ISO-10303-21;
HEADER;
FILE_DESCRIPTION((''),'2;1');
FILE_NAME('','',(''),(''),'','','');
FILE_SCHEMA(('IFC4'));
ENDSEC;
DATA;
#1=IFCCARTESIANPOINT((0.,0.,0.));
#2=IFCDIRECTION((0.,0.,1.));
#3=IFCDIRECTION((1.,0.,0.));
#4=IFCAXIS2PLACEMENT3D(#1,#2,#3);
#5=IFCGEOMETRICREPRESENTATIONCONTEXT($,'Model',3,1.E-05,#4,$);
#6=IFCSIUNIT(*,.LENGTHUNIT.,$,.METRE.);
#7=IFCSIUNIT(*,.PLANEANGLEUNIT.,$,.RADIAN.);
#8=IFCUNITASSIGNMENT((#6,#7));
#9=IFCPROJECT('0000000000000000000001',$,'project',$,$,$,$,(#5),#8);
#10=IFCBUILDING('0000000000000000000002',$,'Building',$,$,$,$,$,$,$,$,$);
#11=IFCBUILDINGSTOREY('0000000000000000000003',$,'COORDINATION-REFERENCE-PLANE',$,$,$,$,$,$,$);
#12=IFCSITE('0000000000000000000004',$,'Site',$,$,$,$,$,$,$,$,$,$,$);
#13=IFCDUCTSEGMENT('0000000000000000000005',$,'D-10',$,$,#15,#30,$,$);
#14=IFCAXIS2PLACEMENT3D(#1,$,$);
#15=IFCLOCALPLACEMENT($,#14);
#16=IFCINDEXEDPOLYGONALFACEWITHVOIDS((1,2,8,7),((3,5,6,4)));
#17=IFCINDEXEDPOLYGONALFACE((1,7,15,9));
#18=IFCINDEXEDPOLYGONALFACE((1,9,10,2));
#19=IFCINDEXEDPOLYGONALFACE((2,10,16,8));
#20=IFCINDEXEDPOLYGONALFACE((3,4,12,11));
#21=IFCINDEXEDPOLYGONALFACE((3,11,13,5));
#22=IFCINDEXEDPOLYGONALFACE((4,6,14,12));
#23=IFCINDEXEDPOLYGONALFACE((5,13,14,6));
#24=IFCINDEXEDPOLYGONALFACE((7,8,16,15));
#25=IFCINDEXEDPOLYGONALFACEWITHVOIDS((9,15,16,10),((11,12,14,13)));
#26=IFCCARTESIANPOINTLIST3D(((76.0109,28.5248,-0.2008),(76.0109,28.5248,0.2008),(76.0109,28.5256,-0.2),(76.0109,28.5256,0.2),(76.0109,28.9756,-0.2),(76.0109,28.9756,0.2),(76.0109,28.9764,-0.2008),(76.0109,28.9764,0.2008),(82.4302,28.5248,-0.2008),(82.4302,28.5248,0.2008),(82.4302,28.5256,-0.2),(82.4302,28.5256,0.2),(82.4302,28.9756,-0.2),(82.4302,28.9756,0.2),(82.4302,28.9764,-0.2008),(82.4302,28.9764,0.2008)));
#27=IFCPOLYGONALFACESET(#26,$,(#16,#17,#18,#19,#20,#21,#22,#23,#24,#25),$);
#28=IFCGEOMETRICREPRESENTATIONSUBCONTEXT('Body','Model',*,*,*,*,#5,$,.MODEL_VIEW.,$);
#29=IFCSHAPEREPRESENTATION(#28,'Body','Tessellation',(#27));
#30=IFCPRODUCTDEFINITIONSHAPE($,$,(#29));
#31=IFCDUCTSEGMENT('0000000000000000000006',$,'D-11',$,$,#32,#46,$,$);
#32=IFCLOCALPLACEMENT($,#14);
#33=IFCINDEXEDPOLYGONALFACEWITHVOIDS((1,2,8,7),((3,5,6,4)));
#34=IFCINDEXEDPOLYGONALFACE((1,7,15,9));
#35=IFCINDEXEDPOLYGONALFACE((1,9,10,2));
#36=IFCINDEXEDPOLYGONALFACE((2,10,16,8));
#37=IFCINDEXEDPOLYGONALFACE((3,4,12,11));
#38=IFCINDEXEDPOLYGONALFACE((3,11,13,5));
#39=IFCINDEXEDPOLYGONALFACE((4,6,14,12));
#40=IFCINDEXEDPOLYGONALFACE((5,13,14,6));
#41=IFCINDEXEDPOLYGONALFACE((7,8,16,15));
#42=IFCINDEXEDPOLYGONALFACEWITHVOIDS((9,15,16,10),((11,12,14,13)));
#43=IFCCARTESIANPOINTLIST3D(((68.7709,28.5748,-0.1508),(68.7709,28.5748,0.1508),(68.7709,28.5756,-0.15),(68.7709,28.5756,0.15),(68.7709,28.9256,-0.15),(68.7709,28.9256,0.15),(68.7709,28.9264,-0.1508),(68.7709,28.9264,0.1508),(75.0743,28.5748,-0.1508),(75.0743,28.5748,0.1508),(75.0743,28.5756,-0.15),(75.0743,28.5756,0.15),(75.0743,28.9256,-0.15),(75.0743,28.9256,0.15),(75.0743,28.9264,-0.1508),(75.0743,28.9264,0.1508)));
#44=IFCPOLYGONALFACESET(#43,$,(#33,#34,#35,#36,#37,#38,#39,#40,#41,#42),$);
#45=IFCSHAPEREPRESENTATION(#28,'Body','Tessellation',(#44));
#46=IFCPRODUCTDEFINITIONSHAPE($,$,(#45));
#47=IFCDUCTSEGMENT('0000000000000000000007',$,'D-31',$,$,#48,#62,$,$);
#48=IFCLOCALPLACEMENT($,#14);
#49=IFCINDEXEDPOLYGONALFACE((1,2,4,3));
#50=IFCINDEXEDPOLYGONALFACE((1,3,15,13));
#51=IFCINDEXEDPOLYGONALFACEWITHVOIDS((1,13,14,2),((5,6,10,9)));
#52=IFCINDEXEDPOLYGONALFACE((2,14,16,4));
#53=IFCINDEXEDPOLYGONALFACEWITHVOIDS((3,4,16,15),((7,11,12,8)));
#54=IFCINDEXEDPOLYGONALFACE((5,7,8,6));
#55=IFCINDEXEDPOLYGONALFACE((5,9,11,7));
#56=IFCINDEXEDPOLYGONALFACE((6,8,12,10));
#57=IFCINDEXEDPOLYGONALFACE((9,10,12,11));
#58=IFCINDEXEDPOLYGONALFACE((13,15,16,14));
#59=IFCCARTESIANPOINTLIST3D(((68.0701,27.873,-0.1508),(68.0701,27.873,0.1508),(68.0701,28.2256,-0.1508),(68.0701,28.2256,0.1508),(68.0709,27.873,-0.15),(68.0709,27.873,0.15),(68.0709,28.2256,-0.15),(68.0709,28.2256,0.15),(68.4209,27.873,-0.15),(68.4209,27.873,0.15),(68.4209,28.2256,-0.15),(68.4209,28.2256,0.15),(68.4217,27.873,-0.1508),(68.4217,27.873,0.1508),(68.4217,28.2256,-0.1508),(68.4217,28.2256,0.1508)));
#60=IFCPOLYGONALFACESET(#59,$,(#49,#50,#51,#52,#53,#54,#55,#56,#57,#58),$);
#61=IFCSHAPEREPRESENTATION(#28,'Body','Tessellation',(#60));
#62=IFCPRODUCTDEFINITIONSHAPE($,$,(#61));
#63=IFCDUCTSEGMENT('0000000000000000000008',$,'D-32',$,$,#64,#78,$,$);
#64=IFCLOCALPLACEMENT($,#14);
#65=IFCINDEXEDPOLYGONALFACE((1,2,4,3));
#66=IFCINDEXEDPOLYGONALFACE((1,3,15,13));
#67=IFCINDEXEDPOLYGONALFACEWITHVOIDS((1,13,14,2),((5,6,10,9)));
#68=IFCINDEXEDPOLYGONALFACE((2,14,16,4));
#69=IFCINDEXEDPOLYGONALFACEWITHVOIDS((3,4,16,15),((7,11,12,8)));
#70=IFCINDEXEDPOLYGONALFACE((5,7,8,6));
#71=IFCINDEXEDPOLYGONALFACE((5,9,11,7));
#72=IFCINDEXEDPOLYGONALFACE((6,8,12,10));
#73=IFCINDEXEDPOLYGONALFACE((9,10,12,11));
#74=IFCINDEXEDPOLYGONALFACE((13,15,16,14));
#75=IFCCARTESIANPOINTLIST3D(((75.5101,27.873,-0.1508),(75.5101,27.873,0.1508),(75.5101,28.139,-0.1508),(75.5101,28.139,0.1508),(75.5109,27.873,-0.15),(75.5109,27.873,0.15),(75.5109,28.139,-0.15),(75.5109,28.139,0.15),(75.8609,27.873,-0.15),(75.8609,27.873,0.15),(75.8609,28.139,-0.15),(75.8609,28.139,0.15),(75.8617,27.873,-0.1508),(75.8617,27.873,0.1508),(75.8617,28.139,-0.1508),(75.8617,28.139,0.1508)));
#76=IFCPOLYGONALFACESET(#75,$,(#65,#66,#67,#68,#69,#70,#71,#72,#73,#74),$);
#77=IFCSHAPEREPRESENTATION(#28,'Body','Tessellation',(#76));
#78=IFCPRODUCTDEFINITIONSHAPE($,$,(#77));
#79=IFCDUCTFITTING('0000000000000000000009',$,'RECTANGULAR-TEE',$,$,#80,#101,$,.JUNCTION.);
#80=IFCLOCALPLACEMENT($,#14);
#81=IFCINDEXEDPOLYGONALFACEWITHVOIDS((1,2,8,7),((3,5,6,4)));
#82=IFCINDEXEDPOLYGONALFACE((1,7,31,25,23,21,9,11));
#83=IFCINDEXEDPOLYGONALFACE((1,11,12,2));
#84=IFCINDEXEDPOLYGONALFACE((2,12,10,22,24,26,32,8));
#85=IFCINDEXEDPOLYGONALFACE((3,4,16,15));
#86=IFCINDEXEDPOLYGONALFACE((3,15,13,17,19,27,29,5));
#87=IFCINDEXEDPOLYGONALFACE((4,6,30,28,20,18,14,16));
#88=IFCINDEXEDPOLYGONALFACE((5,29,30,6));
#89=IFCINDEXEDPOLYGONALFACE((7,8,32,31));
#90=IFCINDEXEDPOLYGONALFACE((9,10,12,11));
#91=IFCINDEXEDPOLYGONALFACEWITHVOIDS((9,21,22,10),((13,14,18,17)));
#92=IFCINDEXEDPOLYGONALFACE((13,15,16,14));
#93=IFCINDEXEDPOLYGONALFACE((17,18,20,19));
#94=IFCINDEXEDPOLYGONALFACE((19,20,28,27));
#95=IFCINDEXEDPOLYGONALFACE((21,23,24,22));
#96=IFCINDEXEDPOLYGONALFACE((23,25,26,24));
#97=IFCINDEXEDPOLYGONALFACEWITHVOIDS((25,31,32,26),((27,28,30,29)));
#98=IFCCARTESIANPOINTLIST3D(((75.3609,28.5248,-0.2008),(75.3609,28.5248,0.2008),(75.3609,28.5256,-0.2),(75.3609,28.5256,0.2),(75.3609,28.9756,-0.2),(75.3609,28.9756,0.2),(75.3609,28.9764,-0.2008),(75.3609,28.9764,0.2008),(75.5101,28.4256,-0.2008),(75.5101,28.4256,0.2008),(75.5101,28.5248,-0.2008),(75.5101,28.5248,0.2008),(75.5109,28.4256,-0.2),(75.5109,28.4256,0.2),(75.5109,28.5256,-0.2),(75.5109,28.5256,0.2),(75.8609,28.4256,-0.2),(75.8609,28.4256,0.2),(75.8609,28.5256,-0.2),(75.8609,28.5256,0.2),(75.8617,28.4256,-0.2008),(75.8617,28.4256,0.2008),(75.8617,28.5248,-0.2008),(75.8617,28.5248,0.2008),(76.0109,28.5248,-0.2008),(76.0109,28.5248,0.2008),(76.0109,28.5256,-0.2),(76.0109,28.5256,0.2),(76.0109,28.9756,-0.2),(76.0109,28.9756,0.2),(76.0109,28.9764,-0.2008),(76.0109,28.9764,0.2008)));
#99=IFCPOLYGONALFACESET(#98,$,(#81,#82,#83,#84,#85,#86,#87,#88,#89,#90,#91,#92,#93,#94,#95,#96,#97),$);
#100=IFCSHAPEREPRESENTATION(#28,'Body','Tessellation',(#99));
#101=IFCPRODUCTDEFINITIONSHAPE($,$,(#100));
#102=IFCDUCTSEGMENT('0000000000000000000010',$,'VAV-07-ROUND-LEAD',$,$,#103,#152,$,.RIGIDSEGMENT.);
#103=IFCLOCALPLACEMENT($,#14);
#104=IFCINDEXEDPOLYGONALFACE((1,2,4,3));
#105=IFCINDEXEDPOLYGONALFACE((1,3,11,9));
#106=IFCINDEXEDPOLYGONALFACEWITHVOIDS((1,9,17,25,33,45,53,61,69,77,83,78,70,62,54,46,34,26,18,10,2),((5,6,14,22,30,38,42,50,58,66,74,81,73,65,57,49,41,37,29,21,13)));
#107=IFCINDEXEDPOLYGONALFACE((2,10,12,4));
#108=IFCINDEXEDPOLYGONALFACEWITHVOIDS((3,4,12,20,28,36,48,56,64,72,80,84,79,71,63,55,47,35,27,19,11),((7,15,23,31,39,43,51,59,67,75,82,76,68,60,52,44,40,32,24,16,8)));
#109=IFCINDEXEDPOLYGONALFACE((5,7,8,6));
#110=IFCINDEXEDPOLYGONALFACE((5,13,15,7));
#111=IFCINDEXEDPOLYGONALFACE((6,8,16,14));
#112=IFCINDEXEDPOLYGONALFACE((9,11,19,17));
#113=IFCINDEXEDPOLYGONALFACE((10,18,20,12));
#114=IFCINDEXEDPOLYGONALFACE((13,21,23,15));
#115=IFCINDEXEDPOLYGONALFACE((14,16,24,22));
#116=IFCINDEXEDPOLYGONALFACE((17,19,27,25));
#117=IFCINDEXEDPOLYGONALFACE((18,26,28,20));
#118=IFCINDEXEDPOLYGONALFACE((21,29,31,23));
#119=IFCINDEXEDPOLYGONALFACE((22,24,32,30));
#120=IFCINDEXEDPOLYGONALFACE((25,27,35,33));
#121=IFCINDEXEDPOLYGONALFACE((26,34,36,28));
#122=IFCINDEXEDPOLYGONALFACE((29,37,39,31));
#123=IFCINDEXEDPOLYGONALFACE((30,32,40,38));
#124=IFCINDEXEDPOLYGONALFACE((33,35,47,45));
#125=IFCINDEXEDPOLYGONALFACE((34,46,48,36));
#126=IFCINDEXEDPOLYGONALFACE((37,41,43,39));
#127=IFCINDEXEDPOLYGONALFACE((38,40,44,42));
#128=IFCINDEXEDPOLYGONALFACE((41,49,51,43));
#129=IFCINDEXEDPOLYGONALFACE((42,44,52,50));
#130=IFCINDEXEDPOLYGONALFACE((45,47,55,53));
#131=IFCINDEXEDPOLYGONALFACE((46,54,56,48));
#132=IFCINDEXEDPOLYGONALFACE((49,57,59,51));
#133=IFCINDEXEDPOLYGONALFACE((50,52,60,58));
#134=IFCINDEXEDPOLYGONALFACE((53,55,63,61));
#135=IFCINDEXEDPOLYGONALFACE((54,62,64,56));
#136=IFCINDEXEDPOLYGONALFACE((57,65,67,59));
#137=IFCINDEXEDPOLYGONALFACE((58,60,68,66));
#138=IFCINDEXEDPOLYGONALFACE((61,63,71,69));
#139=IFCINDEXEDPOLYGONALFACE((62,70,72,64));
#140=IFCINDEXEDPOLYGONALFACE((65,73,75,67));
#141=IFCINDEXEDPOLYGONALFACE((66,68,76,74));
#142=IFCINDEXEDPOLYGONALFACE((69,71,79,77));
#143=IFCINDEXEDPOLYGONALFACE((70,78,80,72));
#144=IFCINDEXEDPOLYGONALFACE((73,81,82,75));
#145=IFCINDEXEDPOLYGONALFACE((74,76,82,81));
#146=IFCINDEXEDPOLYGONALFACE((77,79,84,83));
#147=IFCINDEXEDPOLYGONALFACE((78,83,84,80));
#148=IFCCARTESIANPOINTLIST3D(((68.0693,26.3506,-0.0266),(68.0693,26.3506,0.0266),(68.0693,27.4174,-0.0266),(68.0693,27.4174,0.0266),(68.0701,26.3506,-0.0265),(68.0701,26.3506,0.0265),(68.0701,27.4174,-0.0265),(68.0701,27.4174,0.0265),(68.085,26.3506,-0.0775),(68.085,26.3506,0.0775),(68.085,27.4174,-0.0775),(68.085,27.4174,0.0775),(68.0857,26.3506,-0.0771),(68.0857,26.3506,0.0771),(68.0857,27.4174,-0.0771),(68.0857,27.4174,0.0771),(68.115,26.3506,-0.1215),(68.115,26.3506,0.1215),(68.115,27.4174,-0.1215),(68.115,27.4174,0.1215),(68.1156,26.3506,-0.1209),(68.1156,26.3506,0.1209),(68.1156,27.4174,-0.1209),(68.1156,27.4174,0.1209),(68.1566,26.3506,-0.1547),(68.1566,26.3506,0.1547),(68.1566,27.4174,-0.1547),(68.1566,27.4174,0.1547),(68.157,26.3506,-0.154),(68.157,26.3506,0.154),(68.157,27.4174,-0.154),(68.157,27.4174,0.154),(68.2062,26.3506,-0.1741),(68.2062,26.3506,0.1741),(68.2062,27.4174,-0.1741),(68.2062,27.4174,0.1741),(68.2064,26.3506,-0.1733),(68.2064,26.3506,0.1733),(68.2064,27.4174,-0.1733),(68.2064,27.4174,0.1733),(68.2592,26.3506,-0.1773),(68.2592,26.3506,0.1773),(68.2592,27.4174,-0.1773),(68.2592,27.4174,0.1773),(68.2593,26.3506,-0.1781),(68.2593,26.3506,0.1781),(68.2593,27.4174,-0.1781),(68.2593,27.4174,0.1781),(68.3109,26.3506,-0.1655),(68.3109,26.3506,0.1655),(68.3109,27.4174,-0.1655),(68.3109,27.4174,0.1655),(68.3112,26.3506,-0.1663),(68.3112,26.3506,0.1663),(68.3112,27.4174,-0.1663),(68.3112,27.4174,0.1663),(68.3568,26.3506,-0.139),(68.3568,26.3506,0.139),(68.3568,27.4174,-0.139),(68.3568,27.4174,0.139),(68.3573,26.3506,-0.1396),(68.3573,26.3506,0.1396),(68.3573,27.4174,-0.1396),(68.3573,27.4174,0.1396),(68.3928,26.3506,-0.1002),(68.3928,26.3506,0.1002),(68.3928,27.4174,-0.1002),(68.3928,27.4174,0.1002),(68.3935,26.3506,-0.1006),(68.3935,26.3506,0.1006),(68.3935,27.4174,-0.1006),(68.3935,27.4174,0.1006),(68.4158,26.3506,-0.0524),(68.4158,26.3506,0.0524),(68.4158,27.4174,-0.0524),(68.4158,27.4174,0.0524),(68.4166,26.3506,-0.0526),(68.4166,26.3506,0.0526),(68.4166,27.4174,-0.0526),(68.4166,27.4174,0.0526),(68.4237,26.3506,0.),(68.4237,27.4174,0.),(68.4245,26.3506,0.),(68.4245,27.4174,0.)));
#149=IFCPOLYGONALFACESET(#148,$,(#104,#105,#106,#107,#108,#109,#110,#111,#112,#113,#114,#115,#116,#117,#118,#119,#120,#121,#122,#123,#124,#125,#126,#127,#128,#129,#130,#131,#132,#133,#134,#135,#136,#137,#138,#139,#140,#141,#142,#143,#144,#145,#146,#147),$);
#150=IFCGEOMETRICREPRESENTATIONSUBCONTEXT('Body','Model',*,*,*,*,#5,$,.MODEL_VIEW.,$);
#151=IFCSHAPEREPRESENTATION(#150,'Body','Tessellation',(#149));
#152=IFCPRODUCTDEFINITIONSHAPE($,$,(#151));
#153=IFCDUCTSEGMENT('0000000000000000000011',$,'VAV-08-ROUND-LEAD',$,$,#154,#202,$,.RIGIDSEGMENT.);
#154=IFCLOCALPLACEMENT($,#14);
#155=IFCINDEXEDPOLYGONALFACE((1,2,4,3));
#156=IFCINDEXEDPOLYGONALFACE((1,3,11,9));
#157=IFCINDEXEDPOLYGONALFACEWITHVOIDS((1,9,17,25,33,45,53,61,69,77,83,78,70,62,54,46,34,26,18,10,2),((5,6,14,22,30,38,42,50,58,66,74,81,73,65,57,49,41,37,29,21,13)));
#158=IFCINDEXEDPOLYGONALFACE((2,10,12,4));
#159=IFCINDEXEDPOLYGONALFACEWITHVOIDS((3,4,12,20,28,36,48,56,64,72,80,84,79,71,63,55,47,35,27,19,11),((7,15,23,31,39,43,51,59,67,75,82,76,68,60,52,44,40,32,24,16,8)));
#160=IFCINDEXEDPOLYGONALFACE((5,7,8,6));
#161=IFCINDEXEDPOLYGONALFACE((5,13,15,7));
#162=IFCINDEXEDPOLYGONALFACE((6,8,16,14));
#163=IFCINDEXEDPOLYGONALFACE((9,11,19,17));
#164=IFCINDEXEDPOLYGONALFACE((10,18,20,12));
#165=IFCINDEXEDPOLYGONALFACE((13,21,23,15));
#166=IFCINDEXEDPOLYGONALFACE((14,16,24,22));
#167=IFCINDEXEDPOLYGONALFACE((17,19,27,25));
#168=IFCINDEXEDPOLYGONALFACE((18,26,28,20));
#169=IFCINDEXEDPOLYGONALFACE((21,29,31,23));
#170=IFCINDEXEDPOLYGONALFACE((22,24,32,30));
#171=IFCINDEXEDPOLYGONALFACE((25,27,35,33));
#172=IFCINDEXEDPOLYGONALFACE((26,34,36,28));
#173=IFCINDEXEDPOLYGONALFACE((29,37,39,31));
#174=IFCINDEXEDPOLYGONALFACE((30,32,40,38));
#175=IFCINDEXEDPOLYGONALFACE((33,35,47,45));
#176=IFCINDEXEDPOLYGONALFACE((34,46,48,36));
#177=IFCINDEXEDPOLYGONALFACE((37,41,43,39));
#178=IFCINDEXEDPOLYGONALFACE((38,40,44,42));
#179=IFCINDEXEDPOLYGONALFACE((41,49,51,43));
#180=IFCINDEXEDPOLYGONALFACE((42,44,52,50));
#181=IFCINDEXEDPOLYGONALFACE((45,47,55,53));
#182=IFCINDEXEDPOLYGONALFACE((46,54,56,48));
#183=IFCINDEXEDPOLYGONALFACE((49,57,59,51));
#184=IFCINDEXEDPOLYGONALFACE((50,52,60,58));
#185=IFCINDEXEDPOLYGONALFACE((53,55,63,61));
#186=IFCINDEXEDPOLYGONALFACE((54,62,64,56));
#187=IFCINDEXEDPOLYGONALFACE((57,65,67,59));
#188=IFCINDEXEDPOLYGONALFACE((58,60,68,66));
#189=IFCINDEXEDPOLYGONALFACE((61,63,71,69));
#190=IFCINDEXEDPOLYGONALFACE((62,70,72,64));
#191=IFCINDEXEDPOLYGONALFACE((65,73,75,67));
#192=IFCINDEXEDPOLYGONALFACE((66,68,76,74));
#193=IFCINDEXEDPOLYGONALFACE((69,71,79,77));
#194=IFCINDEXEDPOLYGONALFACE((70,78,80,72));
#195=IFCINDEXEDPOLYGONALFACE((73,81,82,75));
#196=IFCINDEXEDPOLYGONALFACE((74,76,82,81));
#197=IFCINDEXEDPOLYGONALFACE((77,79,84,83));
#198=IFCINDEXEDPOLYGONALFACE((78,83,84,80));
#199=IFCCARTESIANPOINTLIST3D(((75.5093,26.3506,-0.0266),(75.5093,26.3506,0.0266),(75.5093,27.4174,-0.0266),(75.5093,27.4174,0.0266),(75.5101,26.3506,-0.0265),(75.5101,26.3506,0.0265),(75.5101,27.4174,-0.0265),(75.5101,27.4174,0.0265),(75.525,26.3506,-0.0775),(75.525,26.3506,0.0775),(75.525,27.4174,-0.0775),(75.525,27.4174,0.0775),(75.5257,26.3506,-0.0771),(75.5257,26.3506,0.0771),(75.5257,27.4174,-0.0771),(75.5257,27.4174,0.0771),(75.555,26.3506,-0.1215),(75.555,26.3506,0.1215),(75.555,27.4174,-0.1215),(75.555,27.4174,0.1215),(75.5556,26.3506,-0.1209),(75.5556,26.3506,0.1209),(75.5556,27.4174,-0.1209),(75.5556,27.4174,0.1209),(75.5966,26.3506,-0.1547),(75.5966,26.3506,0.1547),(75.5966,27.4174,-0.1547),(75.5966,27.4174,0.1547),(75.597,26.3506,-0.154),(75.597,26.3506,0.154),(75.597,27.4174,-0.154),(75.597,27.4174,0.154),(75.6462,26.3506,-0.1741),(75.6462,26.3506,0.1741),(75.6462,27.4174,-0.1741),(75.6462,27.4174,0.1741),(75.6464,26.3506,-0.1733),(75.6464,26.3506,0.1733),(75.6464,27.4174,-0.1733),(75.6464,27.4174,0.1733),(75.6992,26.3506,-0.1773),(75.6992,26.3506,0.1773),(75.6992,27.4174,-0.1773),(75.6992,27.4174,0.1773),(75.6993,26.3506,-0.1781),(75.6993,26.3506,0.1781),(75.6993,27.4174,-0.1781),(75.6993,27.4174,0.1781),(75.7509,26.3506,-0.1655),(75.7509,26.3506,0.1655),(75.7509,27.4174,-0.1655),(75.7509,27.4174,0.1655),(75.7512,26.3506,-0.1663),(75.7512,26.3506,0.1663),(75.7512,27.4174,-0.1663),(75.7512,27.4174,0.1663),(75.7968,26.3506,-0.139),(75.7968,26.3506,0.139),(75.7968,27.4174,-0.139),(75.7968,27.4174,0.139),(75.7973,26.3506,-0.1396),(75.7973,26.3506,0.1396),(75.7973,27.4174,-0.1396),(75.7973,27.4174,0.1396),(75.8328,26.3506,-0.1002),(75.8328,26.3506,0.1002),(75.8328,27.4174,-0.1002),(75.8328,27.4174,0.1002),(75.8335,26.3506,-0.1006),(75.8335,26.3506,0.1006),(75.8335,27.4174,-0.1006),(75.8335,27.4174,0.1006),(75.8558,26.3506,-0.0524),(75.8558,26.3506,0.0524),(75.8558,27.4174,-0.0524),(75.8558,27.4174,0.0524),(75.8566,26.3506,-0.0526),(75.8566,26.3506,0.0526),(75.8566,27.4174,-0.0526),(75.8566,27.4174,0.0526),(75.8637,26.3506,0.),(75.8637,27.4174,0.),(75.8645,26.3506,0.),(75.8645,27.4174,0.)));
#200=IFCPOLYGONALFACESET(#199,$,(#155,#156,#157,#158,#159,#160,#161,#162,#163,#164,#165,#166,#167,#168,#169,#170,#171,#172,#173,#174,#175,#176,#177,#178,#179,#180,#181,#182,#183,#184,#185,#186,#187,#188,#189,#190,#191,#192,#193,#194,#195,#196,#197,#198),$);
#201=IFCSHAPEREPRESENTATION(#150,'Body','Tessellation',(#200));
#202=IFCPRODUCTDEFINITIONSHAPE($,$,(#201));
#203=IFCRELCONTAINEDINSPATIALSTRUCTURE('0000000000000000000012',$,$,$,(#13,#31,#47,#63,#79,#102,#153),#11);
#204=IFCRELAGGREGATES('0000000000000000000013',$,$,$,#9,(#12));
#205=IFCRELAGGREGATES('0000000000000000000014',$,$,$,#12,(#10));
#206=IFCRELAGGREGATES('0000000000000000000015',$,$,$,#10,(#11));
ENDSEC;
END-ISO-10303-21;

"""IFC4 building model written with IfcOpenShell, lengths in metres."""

from ifc_helpers import new_model, si_unit, frame, origin, origin_with_axes, place, context, subcontext, project, spatial, rectangle, hollow_rectangle, hollow_circle, extrude, boolean, element, save


model = new_model("IFC4")

# Units and contexts
model_context = context("Model", 3, precision=1e-05, world=origin_with_axes())
body_context_1 = subcontext(model_context, "Body", "Model", "MODEL_VIEW")
body_context_2 = subcontext(model_context, "Body", "Model", "MODEL_VIEW")
ifc_project = project(units=[si_unit("LENGTHUNIT", "METRE"), si_unit("PLANEANGLEUNIT", "RADIAN")], contexts=[model_context])

# Site, building, storey
site = spatial("IfcSite", under=ifc_project, Name="Site")
building = spatial("IfcBuilding", under=site, Name="Building")
storey = spatial("IfcBuildingStorey", under=building, Name="COORDINATION-REFERENCE-PLANE")

# Duct segments
duct_segment_1_placement = place(None, frame((76.0109, 28.7506, 0.0), z_axis=(1.0, 0.0, 0.0), x_axis=(0.0, 1.0, 0.0)))
element("IfcDuctSegment", 1, at=duct_segment_1_placement, inside=storey, Name="D-10", context=body_context_1, shape_type="SweptSolid", body=[
    extrude(hollow_rectangle(XDim=0.4516, YDim=0.4016, WallThickness=0.0008), origin(), (0.0, 0.0, 1.0), 6.4193),
])
duct_segment_2_placement = place(None, frame((68.7709, 28.7506, 0.0), z_axis=(1.0, 0.0, 0.0), x_axis=(0.0, 1.0, 0.0)))
element("IfcDuctSegment", 2, at=duct_segment_2_placement, inside=storey, Name="D-11", context=body_context_1, shape_type="SweptSolid", body=[
    extrude(hollow_rectangle(XDim=0.3516, YDim=0.3016, WallThickness=0.0008), origin(), (0.0, 0.0, 1.0), 6.3034),
])
duct_segment_3_placement = place(None, frame((68.2459, 27.873, 0.0), z_axis=(0.0, 1.0, 0.0), x_axis=(1.0, 0.0, 0.0)))
element("IfcDuctSegment", 3, at=duct_segment_3_placement, inside=storey, Name="D-31", context=body_context_1, shape_type="SweptSolid", body=[
    extrude(hollow_rectangle(XDim=0.3516, YDim=0.3016, WallThickness=0.0008), origin(), (0.0, 0.0, 1.0), 0.3526),
])
duct_segment_4_placement = place(None, frame((75.6859, 27.873, 0.0), z_axis=(0.0, 1.0, 0.0), x_axis=(1.0, 0.0, 0.0)))
element("IfcDuctSegment", 4, at=duct_segment_4_placement, inside=storey, Name="D-32", context=body_context_1, shape_type="SweptSolid", body=[
    extrude(hollow_rectangle(XDim=0.3516, YDim=0.3016, WallThickness=0.0008), origin(), (0.0, 0.0, 1.0), 0.266),
])

# Duct fitting
duct_fitting_1_placement = place(None, frame((75.6859, 28.7506, 0.0), z_axis=(-1.0, 0.0, 0.0), x_axis=(0.0, -1.0, 0.0)))
solid = boolean("UNION", extrude(rectangle(XDim=0.45, YDim=0.4), frame((0.0, 0.0, -0.325), z_axis=(0.0, 0.0, 1.0), x_axis=(1.0, 0.0, 0.0)), (0.0, 0.0, 1.0), 0.65), extrude(rectangle(XDim=0.35, YDim=0.4), frame((0.0, 0.0, 0.0), z_axis=(1.0, 0.0, 0.0), x_axis=(0.0, 0.0, -1.0)), (0.0, 0.0, 1.0), 0.325))
element("IfcDuctFitting", 5, at=duct_fitting_1_placement, inside=storey, Name="RECTANGULAR-TEE", PredefinedType="JUNCTION", context=body_context_1, shape_type="CSG", body=[
    boolean("DIFFERENCE", boolean("UNION", extrude(rectangle(XDim=0.4516, YDim=0.4016), frame((0.0, 0.0, -0.325), z_axis=(0.0, 0.0, 1.0), x_axis=(1.0, 0.0, 0.0)), (0.0, 0.0, 1.0), 0.65), extrude(rectangle(XDim=0.3516, YDim=0.4016), frame((0.0, 0.0, 0.0), z_axis=(1.0, 0.0, 0.0), x_axis=(0.0, 0.0, -1.0)), (0.0, 0.0, 1.0), 0.325)), solid),
])

# Duct segments
for number, where, z_axis, x_axis, name in (
    (6, (68.2459, 27.4174, 0.0), (0.0, -1.0, 0.0), (1.0, 0.0, 0.0), "VAV-07-ROUND-LEAD"),
    (7, (75.6859, 27.4174, 0.0), (0.0, -1.0, 0.0), (1.0, 0.0, 0.0), "VAV-08-ROUND-LEAD"),
):
    element("IfcDuctSegment", number, at=place(None, frame(where, z_axis=z_axis, x_axis=x_axis)), inside=storey, Name=name, PredefinedType="RIGIDSEGMENT", context=body_context_2, shape_type="SweptSolid", body=[
        extrude(hollow_circle(Radius=0.1786, WallThickness=0.0008), origin(), (0.0, 0.0, 1.0), 1.0668),
    ])

save(model, "model.ifc")
